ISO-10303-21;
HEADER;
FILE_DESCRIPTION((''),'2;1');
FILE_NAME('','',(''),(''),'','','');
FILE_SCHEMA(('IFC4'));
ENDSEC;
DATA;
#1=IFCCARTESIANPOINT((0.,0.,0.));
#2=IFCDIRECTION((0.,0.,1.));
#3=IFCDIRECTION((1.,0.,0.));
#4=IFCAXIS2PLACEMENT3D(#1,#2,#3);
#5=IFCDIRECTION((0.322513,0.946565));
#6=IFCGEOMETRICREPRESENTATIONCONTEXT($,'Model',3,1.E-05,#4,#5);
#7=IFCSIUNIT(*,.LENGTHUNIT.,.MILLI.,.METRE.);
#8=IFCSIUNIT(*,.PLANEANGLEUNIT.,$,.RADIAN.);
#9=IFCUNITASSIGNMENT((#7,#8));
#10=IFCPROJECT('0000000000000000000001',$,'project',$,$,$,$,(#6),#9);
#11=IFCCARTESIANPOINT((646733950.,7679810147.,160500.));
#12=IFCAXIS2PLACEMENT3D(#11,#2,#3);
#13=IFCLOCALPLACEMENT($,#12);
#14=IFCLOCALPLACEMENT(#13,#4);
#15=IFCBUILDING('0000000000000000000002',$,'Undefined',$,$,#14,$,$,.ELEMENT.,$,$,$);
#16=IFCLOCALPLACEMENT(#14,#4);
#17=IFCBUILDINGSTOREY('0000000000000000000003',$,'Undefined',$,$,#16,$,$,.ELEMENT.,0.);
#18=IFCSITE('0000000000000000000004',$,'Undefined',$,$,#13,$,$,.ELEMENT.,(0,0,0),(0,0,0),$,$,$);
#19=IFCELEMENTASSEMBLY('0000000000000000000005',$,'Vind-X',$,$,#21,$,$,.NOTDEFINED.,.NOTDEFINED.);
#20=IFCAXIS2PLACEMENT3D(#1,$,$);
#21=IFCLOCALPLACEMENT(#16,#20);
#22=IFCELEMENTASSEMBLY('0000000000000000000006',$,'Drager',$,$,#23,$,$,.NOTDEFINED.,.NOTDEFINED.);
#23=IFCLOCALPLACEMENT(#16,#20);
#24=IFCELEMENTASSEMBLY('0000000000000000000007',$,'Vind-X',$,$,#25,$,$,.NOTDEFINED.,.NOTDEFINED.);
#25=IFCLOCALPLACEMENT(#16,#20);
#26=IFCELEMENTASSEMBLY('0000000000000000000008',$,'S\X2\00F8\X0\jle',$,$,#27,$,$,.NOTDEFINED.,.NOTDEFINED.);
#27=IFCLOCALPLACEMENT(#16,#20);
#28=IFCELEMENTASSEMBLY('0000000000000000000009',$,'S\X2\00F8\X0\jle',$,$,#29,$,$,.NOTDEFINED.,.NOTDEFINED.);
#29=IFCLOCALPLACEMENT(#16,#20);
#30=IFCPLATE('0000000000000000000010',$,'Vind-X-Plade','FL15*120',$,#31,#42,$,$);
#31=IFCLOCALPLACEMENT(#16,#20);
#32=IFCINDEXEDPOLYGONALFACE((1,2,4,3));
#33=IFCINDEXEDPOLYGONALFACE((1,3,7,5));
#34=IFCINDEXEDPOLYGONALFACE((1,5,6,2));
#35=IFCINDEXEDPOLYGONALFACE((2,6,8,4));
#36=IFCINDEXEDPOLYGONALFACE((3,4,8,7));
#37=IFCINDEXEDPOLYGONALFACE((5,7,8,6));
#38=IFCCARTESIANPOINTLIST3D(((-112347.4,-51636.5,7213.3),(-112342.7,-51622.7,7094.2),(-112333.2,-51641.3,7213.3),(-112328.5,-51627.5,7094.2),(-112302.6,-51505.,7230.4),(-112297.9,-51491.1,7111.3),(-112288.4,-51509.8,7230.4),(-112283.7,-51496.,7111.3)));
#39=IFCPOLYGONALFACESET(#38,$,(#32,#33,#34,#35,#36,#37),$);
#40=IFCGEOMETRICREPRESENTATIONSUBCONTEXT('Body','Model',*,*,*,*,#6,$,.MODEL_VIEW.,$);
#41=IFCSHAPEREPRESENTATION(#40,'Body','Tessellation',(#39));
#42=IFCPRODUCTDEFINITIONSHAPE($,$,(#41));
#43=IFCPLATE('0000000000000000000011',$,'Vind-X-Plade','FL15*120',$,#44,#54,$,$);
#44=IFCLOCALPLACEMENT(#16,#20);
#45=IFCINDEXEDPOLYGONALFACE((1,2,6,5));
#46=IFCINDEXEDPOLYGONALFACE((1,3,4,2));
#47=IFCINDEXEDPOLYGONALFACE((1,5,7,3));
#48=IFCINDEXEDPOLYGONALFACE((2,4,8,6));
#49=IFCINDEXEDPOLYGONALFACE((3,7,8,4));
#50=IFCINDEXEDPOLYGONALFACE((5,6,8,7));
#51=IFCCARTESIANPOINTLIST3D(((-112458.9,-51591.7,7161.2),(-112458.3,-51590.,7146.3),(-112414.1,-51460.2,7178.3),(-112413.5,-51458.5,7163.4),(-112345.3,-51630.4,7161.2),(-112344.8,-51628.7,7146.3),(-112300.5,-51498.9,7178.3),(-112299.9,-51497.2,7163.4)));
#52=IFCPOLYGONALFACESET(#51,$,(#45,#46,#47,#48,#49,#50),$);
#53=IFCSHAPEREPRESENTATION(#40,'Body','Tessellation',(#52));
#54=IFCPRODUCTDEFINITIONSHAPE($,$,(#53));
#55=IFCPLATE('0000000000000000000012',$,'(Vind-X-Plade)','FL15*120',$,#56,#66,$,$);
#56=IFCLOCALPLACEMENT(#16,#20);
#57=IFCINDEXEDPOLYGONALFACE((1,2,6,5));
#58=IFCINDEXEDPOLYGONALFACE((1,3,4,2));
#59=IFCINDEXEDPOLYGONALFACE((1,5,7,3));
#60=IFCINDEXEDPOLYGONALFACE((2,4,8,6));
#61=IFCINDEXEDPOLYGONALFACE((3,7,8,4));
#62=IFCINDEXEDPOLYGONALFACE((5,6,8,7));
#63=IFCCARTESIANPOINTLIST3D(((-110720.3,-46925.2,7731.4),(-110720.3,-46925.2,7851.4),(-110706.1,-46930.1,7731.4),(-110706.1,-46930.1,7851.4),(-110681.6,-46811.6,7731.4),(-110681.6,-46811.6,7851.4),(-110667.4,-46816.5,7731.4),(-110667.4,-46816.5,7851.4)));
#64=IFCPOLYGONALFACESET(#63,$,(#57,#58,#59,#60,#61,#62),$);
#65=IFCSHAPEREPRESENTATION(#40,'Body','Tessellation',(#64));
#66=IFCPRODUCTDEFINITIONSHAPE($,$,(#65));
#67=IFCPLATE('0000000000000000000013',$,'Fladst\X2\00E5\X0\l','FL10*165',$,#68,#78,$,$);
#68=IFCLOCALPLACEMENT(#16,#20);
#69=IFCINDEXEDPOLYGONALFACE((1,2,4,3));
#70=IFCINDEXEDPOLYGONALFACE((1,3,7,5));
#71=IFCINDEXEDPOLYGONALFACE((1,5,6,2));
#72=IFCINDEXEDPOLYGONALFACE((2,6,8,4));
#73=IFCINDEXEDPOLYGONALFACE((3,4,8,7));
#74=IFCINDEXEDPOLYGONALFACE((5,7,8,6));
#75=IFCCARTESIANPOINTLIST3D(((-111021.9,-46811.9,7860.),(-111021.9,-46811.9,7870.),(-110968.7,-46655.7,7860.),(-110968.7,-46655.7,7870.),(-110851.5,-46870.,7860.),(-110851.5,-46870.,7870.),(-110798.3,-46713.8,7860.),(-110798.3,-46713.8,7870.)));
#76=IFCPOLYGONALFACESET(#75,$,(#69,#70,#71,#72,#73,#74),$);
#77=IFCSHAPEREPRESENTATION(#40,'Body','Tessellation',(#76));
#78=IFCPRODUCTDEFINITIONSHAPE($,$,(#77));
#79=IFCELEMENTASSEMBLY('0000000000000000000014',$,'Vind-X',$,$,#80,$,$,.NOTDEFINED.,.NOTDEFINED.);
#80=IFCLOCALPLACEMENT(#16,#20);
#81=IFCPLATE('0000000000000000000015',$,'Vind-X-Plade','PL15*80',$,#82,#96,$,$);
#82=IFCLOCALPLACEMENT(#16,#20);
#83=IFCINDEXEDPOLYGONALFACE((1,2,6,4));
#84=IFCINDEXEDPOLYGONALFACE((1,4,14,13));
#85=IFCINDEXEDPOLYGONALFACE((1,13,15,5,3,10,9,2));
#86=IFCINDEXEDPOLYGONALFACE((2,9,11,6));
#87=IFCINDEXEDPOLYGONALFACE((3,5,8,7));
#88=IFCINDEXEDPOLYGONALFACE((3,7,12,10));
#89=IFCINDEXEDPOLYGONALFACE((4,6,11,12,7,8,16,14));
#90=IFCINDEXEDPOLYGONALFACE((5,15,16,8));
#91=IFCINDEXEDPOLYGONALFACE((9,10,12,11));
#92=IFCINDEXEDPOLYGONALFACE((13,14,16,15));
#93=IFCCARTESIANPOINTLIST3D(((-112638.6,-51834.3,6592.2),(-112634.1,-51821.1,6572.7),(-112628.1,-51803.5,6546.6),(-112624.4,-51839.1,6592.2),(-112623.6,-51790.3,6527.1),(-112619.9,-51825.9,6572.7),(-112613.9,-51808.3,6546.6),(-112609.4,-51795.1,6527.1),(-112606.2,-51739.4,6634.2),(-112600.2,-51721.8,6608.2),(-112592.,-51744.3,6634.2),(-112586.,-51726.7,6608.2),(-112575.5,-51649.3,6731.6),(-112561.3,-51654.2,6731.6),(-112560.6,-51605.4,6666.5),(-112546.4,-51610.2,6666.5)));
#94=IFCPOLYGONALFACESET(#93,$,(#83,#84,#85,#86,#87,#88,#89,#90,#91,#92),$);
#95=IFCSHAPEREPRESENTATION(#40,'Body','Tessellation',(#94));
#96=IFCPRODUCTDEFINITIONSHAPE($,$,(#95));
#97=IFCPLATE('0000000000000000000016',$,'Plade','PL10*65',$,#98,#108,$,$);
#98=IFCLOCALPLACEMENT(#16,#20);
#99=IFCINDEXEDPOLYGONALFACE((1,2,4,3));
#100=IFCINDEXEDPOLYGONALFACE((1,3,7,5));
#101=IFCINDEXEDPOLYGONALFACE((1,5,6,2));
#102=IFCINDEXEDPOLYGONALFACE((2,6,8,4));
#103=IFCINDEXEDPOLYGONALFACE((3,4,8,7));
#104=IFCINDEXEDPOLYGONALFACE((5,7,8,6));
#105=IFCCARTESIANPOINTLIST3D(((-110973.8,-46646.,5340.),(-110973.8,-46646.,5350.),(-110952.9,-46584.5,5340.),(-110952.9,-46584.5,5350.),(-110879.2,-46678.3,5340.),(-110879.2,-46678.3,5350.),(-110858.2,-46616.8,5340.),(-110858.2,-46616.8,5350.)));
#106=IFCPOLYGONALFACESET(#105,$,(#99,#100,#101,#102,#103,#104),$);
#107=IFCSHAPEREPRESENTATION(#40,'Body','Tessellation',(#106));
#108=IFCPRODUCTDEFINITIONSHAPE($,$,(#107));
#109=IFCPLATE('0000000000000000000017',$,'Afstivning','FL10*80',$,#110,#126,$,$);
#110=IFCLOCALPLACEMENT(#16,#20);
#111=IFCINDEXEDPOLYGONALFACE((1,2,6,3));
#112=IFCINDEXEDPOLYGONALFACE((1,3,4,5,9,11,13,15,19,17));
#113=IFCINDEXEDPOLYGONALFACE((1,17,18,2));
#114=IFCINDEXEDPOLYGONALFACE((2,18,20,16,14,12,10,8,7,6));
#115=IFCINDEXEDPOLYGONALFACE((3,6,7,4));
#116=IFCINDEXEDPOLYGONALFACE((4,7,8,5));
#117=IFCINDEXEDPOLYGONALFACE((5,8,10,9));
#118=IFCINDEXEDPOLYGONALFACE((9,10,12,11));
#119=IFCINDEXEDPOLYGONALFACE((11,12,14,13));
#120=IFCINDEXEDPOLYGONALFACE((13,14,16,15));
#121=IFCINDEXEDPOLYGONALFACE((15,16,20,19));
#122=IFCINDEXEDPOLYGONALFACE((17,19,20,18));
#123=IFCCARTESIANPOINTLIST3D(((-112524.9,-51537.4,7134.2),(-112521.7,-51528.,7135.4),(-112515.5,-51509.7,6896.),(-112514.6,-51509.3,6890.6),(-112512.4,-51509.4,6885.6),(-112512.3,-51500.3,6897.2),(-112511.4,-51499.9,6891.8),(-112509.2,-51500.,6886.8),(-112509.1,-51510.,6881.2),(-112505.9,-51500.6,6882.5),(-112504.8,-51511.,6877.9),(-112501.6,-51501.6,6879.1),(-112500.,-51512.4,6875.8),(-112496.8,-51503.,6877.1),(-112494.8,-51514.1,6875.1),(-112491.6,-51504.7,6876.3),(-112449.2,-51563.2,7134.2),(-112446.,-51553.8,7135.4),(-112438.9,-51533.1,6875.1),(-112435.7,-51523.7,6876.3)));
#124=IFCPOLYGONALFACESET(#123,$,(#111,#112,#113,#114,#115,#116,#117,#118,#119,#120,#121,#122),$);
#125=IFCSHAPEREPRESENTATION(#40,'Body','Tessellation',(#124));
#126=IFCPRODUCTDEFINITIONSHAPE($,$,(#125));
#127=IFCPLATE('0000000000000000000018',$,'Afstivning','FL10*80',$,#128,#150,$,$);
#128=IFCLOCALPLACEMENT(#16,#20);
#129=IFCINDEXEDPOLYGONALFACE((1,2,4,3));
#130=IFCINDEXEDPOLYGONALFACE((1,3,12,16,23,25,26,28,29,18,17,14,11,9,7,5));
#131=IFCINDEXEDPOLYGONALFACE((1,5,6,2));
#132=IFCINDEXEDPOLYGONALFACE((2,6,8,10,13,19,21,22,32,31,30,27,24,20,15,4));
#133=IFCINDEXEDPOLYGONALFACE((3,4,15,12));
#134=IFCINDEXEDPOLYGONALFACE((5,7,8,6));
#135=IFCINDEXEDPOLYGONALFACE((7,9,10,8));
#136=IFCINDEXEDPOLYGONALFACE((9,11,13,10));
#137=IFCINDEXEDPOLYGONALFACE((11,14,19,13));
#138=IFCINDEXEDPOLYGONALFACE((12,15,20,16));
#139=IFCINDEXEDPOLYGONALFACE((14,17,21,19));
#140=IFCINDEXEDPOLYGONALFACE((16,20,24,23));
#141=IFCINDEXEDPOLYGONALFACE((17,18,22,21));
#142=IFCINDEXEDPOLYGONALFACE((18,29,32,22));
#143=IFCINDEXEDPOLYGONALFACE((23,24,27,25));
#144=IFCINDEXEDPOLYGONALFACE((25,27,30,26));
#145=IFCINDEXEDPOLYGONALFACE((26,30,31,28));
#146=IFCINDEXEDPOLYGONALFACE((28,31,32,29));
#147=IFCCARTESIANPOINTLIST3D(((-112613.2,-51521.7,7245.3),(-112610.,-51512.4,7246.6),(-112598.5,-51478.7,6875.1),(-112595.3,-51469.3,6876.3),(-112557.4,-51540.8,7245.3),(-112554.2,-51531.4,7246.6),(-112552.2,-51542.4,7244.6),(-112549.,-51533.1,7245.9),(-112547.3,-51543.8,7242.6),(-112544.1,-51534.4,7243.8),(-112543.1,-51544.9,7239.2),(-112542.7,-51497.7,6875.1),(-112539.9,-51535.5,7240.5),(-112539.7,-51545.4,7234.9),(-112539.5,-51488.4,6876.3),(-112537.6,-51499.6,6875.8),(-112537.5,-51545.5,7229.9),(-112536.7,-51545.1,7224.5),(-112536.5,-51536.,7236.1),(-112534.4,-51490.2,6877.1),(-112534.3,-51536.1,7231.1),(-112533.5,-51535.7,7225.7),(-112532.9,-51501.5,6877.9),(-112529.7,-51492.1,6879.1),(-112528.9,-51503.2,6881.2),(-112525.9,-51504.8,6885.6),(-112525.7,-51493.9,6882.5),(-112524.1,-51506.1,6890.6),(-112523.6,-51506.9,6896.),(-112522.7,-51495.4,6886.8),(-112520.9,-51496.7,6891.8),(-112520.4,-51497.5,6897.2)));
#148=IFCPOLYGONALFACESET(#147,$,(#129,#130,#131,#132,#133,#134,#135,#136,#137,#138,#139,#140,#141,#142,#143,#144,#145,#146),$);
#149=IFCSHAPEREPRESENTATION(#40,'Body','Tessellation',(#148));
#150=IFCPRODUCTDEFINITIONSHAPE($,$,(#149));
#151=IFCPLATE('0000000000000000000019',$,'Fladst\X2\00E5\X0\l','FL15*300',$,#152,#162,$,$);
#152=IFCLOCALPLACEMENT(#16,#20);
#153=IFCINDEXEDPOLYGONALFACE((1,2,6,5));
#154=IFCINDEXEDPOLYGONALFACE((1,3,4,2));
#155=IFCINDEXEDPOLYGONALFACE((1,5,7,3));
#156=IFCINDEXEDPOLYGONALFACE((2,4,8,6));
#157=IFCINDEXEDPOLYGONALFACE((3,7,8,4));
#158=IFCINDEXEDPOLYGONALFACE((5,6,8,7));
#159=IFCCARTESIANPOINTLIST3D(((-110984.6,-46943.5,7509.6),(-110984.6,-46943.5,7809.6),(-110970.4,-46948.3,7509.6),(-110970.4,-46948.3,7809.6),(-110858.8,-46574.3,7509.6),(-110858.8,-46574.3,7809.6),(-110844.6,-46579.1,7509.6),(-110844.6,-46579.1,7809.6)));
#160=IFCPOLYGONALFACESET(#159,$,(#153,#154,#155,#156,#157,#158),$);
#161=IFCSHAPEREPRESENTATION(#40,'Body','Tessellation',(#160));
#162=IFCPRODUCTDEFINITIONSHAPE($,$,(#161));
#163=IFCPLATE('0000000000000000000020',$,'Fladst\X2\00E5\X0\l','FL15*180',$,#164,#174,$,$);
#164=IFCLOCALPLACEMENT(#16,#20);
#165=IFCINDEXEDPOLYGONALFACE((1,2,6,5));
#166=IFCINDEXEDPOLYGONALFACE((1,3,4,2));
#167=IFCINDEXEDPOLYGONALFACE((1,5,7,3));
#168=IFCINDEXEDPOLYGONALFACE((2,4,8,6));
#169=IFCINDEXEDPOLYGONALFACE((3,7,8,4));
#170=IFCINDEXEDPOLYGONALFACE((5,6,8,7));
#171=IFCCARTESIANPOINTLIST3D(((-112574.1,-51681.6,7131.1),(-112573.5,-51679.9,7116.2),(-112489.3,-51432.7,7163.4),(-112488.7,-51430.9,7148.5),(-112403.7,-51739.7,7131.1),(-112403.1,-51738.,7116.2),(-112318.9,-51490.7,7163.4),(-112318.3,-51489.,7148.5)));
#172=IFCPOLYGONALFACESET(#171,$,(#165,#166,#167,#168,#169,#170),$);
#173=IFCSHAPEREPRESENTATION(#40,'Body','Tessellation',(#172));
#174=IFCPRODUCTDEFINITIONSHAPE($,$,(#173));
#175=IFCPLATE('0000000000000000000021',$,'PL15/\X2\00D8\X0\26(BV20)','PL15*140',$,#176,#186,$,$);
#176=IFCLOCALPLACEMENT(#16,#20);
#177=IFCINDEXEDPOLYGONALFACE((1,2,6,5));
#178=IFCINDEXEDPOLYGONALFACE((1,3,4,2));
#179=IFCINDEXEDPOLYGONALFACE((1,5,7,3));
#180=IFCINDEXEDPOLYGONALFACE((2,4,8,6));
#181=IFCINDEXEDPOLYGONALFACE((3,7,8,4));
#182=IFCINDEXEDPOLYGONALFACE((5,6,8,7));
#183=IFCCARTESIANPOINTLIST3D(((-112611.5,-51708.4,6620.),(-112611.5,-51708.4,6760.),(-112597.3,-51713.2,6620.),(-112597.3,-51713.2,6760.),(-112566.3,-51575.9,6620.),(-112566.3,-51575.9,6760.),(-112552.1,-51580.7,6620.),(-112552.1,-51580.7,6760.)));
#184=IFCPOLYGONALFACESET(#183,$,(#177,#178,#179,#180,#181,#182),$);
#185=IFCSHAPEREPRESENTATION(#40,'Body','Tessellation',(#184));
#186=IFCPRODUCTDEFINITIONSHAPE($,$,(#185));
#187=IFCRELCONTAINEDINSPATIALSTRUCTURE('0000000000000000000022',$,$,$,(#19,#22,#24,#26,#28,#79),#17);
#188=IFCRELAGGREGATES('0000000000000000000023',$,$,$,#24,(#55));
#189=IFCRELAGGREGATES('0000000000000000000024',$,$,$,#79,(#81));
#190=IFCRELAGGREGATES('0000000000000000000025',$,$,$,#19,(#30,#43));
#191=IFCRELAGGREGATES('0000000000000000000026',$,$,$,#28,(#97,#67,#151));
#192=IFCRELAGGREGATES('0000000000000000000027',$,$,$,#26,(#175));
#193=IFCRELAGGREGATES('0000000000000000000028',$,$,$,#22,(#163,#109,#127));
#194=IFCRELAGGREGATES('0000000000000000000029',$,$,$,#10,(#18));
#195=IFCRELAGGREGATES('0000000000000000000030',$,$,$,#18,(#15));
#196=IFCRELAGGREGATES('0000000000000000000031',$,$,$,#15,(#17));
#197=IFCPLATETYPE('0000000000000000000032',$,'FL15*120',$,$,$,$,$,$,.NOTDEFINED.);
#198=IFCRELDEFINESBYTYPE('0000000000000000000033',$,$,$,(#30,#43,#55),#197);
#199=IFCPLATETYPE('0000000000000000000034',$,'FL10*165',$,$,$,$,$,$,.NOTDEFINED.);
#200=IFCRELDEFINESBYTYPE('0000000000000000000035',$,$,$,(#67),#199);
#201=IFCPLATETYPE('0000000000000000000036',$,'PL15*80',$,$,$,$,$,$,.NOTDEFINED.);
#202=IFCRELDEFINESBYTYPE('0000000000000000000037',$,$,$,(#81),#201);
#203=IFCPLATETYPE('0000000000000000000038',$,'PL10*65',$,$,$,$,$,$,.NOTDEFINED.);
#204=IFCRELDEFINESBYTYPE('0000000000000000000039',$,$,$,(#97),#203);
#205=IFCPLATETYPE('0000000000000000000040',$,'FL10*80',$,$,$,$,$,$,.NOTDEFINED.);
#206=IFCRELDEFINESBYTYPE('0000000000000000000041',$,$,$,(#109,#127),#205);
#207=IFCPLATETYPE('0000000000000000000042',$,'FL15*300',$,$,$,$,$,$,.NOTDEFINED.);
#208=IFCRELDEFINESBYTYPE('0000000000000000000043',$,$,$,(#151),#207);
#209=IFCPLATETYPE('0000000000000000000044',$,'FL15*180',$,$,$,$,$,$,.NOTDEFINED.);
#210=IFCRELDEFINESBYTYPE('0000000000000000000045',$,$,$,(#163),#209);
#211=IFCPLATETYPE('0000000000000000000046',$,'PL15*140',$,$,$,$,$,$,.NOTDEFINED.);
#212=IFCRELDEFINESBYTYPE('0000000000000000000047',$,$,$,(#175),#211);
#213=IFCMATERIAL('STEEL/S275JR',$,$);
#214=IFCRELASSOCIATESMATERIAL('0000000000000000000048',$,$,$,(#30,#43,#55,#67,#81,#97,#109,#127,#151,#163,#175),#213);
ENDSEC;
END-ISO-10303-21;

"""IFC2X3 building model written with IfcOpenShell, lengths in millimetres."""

from ifc_helpers import new_model, si_unit, direction, frame, frame_2d, origin_with_axes, place, context, subcontext, project, spatial, polyline, circle_curve, parameter, trimmed, segment, composite_curve, outline, extrude, boolean, material, type_object, element, aggregate, save


model = new_model("IFC2X3")

# Units and contexts
model_context = context("Model", 3, precision=1e-05, world=origin_with_axes(), true_north=direction((0.322513, 0.946565)))
body_context = subcontext(model_context, "Body", "Model", "MODEL_VIEW")
ifc_project = project(units=[si_unit("LENGTHUNIT", "METRE", prefix="MILLI"), si_unit("PLANEANGLEUNIT", "RADIAN")], contexts=[model_context])

# Site, building, storey
site_placement = place(None, frame((646733950.0, 7679810147.0, 160500.0), z_axis=(0.0, 0.0, 1.0), x_axis=(1.0, 0.0, 0.0)))
site = spatial("IfcSite", under=ifc_project, at=site_placement, Name="Undefined", CompositionType="ELEMENT", RefLatitude=(0, 0, 0), RefLongitude=(0, 0, 0))
building_placement = place(site_placement, origin_with_axes())
building = spatial("IfcBuilding", under=site, at=building_placement, Name="Undefined", CompositionType="ELEMENT")
storey_placement = place(building_placement, origin_with_axes())
storey = spatial("IfcBuildingStorey", under=building, at=storey_placement, Name="Undefined", CompositionType="ELEMENT", Elevation=0.0)

# Element assemblies
assembly_1_placement = place(storey_placement, origin_with_axes())
assembly_1 = element("IfcElementAssembly", 1, at=assembly_1_placement, inside=storey, Name="Vind-X", AssemblyPlace="NOTDEFINED", PredefinedType="NOTDEFINED")
assembly_2_placement = place(storey_placement, origin_with_axes())
assembly_2 = element("IfcElementAssembly", 2, at=assembly_2_placement, inside=storey, Name="Drager", AssemblyPlace="NOTDEFINED", PredefinedType="NOTDEFINED")

# Shared definitions
ifc_material_1 = material(Name="STEEL/S275JR")

# Element assemblies
assembly_3_placement = place(storey_placement, origin_with_axes())
assembly_3 = element("IfcElementAssembly", 3, at=assembly_3_placement, inside=storey, Name="Vind-X", AssemblyPlace="NOTDEFINED", PredefinedType="NOTDEFINED")
assembly_4_placement = place(storey_placement, origin_with_axes())
assembly_4 = element("IfcElementAssembly", 4, at=assembly_4_placement, inside=storey, Name="Søjle", AssemblyPlace="NOTDEFINED", PredefinedType="NOTDEFINED")
assembly_5_placement = place(storey_placement, origin_with_axes())
assembly_5 = element("IfcElementAssembly", 5, at=assembly_5_placement, inside=storey, Name="Søjle", AssemblyPlace="NOTDEFINED", PredefinedType="NOTDEFINED")

# Plates
plate_type_1 = type_object("IfcPlateType", Name="FL15*120", PredefinedType="NOTDEFINED")
plate_1_placement = place(assembly_1_placement, frame((-112290.8, -51493.5, 7111.3), z_axis=(-0.946565, 0.322513, 0.0), x_axis=(-0.320109, -0.93951, -0.121869)))
plate_1 = element("IfcPlate", 6, at=plate_1_placement, type_object=plate_type_1, material=ifc_material_1, Name="Vind-X-Plade", Description="FL15*120", context=body_context, shape_type="SweptSolid", body=[
    extrude(outline(polyline([(0.0, 0.0), (140.0, 0.0), (140.0, 120.0), (0.0, 120.0), (0.0, 0.0)])), frame((0.0, 0.0, -7.5), z_axis=(0.0, 0.0, 1.0), x_axis=(1.0, 0.0, 0.0)), (0.0, 0.0, 1.0), 15.0),
])
plate_2_placement = place(assembly_1_placement, frame((-112436.2, -51525.1, 7162.3), z_axis=(0.039304, 0.115357, -0.992546), x_axis=(0.946565, -0.322513, 0.0)))
plate_2 = element("IfcPlate", 7, at=plate_2_placement, type_object=plate_type_1, material=ifc_material_1, Name="Vind-X-Plade", Description="FL15*120", context=body_context, shape_type="SweptSolid", body=[
    extrude(outline(polyline([(0.0, -70.0), (0.0, 70.0), (120.0, 70.0), (120.0, -70.0), (0.0, -70.0)])), frame((0.0, 0.0, -7.5), z_axis=(0.0, 0.0, 1.0), x_axis=(1.0, 0.0, 0.0)), (0.0, 0.0, 1.0), 15.0),
])
plate_3_placement = place(assembly_3_placement, frame((-110713.2, -46927.6, 7851.4), z_axis=(-0.946565, 0.322513, 0.0), x_axis=(0.322513, 0.946565, 0.0)))
plate_3 = element("IfcPlate", 8, at=plate_3_placement, type_object=plate_type_1, material=ifc_material_1, Name="(Vind-X-Plade)", Description="FL15*120", context=body_context, shape_type="SweptSolid", body=[
    extrude(outline(polyline([(0.0, 0.0), (120.0, 0.0), (120.0, 120.0), (0.0, 120.0), (0.0, 0.0)])), frame((0.0, 0.0, -7.5), z_axis=(0.0, 0.0, 1.0), x_axis=(1.0, 0.0, 0.0)), (0.0, 0.0, 1.0), 15.0),
])
aggregate(assembly_3, [plate_3])
plate_type_2 = type_object("IfcPlateType", Name="FL10*165", PredefinedType="NOTDEFINED")
plate_4_placement = place(assembly_5_placement, frame((-110824.9, -46791.9, 7865.0), z_axis=(0.0, 0.0, -1.0), x_axis=(-0.946565, 0.322513, 0.0)))
plate_4 = element("IfcPlate", 9, at=plate_4_placement, type_object=plate_type_2, material=ifc_material_1, Name="Fladstål", Description="FL10*165", context=body_context, shape_type="SweptSolid", body=[
    extrude(outline(polyline([(0.0, -82.5), (0.0, 82.5), (180.0, 82.5), (180.0, -82.5), (0.0, -82.5)])), frame((0.0, 0.0, -5.0), z_axis=(0.0, 0.0, 1.0), x_axis=(1.0, 0.0, 0.0)), (0.0, 0.0, 1.0), 10.0),
])

# Element assembly, plate
assembly_6_placement = place(storey_placement, origin_with_axes())
assembly_6 = element("IfcElementAssembly", 10, at=assembly_6_placement, inside=storey, Name="Vind-X", AssemblyPlace="NOTDEFINED", PredefinedType="NOTDEFINED")
plate_type_3 = type_object("IfcPlateType", Name="PL15*80", PredefinedType="NOTDEFINED")
plate_5_placement = place(assembly_6_placement, frame((-112553.5, -51607.8, 6666.5), z_axis=(0.946565, -0.322513, 0.0), x_axis=(-0.187296, -0.549708, 0.814089)))
plate_5 = element("IfcPlate", 11, at=plate_5_placement, type_object=plate_type_3, material=ifc_material_1, Name="Vind-X-Plade", Description="PL15*80", context=body_context, shape_type="CSG", body=[
    boolean("DIFFERENCE", extrude(outline(polyline([(0.0, 0.0), (80.0, 0.0), (80.0, 240.0), (0.0, 240.0), (0.0, 0.0)])), frame((0.0, 0.0, -7.5), z_axis=(0.0, 0.0, 1.0), x_axis=(1.0, 0.0, 0.0)), (0.0, 0.0, 1.0), 15.0), extrude(outline(polyline([(0.0, 0.0), (106.0, 0.0), (106.0, 32.0), (0.0, 32.0), (0.0, 0.0)])), frame((56.0, 240.0, 8.5), z_axis=(0.0, 0.0, -1.0), x_axis=(0.0, -1.0, 0.0)), (0.0, 0.0, 1.0), 17.0)),
])
aggregate(assembly_6, [plate_5])

# Plates
plate_type_4 = type_object("IfcPlateType", Name="PL10*65", PredefinedType="NOTDEFINED")
plate_6_placement = place(assembly_5_placement, frame((-110879.2, -46678.3, 5345.0), z_axis=(0.0, 0.0, 1.0), x_axis=(0.322513, 0.946565, 0.0)))
plate_6 = element("IfcPlate", 12, at=plate_6_placement, type_object=plate_type_4, material=ifc_material_1, Name="Plade", Description="PL10*65", context=body_context, shape_type="SweptSolid", body=[
    extrude(outline(polyline([(0.0, 0.0), (65.0, 0.0), (65.0, 100.0), (0.0, 100.0), (0.0, 0.0)])), frame((0.0, 0.0, -5.0), z_axis=(0.0, 0.0, 1.0), x_axis=(1.0, 0.0, 0.0)), (0.0, 0.0, 1.0), 10.0),
])
plate_type_5 = type_object("IfcPlateType", Name="FL10*80", PredefinedType="NOTDEFINED")
plate_7_placement = place(assembly_2_placement, frame((-112513.1, -51502.6, 6875.7), z_axis=(-0.320109, -0.93951, -0.121869), x_axis=(0.946565, -0.322513, 0.0)))
plate_7 = element("IfcPlate", 13, at=plate_7_placement, type_object=plate_type_5, material=ifc_material_1, Name="Afstivning", Description="FL10*80", context=body_context, shape_type="SweptSolid", body=[
    extrude(outline(composite_curve([segment(trimmed(circle_curve(frame_2d((21.0, 21.0), x_axis=(-1.0, 0.0)), 21.0), [parameter(0.0)], [parameter(1.570796)], True, "PARAMETER"), True, "CONTINUOUS"), segment(polyline([(21.0, 0.0), (80.0, 0.0), (80.0, 261.0), (0.0, 261.0), (0.0, 21.0)]), True, "CONTINUOUS")], self_intersect=True)), frame((0.0, 0.0, -5.0), z_axis=(0.0, 0.0, 1.0), x_axis=(1.0, 0.0, 0.0)), (0.0, 0.0, 1.0), 10.0),
])
plate_8_placement = place(assembly_2_placement, frame((-112596.9, -51474.0, 6875.7), z_axis=(-0.320109, -0.93951, -0.121869), x_axis=(0.946565, -0.322513, 0.0)))
plate_8 = element("IfcPlate", 14, at=plate_8_placement, type_object=plate_type_5, material=ifc_material_1, Name="Afstivning", Description="FL10*80", context=body_context, shape_type="SweptSolid", body=[
    extrude(outline(composite_curve([segment(polyline([(0.0, 0.0), (59.0, 0.0)]), True, "CONTINUOUS"), segment(trimmed(circle_curve(frame_2d((59.0, 21.0), x_axis=(0.0, -1.0)), 21.0), [parameter(0.0)], [parameter(1.570796)], True, "PARAMETER"), True, "CONTINUOUS"), segment(polyline([(80.0, 21.0), (80.0, 352.0)]), True, "CONTINUOUS"), segment(trimmed(circle_curve(frame_2d((59.0, 352.0), x_axis=(1.0, 0.0)), 21.0), [parameter(0.0)], [parameter(1.570796)], True, "PARAMETER"), True, "CONTINUOUS"), segment(polyline([(59.0, 373.0), (0.0, 373.0), (0.0, 0.0)]), True, "CONTINUOUS")], self_intersect=True)), frame((0.0, 0.0, -5.0), z_axis=(0.0, 0.0, 1.0), x_axis=(1.0, 0.0, 0.0)), (0.0, 0.0, 1.0), 10.0),
])
plate_type_6 = type_object("IfcPlateType", Name="FL15*300", PredefinedType="NOTDEFINED")
plate_9_placement = place(assembly_5_placement, frame((-110851.7, -46576.7, 7809.6), z_axis=(-0.946565, 0.322513, 0.0), x_axis=(0.0, 0.0, -1.0)))
plate_9 = element("IfcPlate", 15, at=plate_9_placement, type_object=plate_type_6, material=ifc_material_1, Name="Fladstål", Description="FL15*300", context=body_context, shape_type="SweptSolid", body=[
    extrude(outline(polyline([(0.0, 0.0), (300.0, 0.0), (300.0, 390.0), (0.0, 390.0), (0.0, 0.0)])), frame((0.0, 0.0, -7.5), z_axis=(0.0, 0.0, 1.0), x_axis=(1.0, 0.0, 0.0)), (0.0, 0.0, 1.0), 15.0),
])
plate_type_7 = type_object("IfcPlateType", Name="FL15*180", PredefinedType="NOTDEFINED")
plate_10_placement = place(assembly_2_placement, frame((-112489.0, -51431.8, 7155.9), z_axis=(-0.039304, -0.115357, 0.992546), x_axis=(-0.320109, -0.93951, -0.121869)))
plate_10 = element("IfcPlate", 16, at=plate_10_placement, type_object=plate_type_7, material=ifc_material_1, Name="Fladstål", Description="FL15*180", context=body_context, shape_type="SweptSolid", body=[
    extrude(outline(polyline([(0.0, 0.0), (265.0, 0.0), (265.0, 180.0), (0.0, 180.0), (0.0, 0.0)])), frame((0.0, 0.0, -7.5), z_axis=(0.0, 0.0, 1.0), x_axis=(1.0, 0.0, 0.0)), (0.0, 0.0, 1.0), 15.0),
])
plate_type_8 = type_object("IfcPlateType", Name="PL15*140", PredefinedType="NOTDEFINED")
plate_11_placement = place(assembly_4_placement, frame((-112559.2, -51578.3, 6620.0), z_axis=(-0.946565, 0.322513, 0.0), x_axis=(-0.322513, -0.946565, 0.0)))
plate_11 = element("IfcPlate", 17, at=plate_11_placement, type_object=plate_type_8, material=ifc_material_1, Name="PL15/Ø26(BV20)", Description="PL15*140", context=body_context, shape_type="SweptSolid", body=[
    extrude(outline(polyline([(0.0, 0.0), (140.0, 0.0), (140.0, 140.0), (0.0, 140.0), (0.0, 0.0)])), frame((0.0, 0.0, -7.5), z_axis=(0.0, 0.0, 1.0), x_axis=(1.0, 0.0, 0.0)), (0.0, 0.0, 1.0), 15.0),
])

aggregate(assembly_1, [plate_1, plate_2])
aggregate(assembly_5, [plate_6, plate_4, plate_9])
aggregate(assembly_4, [plate_11])
aggregate(assembly_2, [plate_10, plate_7, plate_8])

save(model, "model.ifc")
